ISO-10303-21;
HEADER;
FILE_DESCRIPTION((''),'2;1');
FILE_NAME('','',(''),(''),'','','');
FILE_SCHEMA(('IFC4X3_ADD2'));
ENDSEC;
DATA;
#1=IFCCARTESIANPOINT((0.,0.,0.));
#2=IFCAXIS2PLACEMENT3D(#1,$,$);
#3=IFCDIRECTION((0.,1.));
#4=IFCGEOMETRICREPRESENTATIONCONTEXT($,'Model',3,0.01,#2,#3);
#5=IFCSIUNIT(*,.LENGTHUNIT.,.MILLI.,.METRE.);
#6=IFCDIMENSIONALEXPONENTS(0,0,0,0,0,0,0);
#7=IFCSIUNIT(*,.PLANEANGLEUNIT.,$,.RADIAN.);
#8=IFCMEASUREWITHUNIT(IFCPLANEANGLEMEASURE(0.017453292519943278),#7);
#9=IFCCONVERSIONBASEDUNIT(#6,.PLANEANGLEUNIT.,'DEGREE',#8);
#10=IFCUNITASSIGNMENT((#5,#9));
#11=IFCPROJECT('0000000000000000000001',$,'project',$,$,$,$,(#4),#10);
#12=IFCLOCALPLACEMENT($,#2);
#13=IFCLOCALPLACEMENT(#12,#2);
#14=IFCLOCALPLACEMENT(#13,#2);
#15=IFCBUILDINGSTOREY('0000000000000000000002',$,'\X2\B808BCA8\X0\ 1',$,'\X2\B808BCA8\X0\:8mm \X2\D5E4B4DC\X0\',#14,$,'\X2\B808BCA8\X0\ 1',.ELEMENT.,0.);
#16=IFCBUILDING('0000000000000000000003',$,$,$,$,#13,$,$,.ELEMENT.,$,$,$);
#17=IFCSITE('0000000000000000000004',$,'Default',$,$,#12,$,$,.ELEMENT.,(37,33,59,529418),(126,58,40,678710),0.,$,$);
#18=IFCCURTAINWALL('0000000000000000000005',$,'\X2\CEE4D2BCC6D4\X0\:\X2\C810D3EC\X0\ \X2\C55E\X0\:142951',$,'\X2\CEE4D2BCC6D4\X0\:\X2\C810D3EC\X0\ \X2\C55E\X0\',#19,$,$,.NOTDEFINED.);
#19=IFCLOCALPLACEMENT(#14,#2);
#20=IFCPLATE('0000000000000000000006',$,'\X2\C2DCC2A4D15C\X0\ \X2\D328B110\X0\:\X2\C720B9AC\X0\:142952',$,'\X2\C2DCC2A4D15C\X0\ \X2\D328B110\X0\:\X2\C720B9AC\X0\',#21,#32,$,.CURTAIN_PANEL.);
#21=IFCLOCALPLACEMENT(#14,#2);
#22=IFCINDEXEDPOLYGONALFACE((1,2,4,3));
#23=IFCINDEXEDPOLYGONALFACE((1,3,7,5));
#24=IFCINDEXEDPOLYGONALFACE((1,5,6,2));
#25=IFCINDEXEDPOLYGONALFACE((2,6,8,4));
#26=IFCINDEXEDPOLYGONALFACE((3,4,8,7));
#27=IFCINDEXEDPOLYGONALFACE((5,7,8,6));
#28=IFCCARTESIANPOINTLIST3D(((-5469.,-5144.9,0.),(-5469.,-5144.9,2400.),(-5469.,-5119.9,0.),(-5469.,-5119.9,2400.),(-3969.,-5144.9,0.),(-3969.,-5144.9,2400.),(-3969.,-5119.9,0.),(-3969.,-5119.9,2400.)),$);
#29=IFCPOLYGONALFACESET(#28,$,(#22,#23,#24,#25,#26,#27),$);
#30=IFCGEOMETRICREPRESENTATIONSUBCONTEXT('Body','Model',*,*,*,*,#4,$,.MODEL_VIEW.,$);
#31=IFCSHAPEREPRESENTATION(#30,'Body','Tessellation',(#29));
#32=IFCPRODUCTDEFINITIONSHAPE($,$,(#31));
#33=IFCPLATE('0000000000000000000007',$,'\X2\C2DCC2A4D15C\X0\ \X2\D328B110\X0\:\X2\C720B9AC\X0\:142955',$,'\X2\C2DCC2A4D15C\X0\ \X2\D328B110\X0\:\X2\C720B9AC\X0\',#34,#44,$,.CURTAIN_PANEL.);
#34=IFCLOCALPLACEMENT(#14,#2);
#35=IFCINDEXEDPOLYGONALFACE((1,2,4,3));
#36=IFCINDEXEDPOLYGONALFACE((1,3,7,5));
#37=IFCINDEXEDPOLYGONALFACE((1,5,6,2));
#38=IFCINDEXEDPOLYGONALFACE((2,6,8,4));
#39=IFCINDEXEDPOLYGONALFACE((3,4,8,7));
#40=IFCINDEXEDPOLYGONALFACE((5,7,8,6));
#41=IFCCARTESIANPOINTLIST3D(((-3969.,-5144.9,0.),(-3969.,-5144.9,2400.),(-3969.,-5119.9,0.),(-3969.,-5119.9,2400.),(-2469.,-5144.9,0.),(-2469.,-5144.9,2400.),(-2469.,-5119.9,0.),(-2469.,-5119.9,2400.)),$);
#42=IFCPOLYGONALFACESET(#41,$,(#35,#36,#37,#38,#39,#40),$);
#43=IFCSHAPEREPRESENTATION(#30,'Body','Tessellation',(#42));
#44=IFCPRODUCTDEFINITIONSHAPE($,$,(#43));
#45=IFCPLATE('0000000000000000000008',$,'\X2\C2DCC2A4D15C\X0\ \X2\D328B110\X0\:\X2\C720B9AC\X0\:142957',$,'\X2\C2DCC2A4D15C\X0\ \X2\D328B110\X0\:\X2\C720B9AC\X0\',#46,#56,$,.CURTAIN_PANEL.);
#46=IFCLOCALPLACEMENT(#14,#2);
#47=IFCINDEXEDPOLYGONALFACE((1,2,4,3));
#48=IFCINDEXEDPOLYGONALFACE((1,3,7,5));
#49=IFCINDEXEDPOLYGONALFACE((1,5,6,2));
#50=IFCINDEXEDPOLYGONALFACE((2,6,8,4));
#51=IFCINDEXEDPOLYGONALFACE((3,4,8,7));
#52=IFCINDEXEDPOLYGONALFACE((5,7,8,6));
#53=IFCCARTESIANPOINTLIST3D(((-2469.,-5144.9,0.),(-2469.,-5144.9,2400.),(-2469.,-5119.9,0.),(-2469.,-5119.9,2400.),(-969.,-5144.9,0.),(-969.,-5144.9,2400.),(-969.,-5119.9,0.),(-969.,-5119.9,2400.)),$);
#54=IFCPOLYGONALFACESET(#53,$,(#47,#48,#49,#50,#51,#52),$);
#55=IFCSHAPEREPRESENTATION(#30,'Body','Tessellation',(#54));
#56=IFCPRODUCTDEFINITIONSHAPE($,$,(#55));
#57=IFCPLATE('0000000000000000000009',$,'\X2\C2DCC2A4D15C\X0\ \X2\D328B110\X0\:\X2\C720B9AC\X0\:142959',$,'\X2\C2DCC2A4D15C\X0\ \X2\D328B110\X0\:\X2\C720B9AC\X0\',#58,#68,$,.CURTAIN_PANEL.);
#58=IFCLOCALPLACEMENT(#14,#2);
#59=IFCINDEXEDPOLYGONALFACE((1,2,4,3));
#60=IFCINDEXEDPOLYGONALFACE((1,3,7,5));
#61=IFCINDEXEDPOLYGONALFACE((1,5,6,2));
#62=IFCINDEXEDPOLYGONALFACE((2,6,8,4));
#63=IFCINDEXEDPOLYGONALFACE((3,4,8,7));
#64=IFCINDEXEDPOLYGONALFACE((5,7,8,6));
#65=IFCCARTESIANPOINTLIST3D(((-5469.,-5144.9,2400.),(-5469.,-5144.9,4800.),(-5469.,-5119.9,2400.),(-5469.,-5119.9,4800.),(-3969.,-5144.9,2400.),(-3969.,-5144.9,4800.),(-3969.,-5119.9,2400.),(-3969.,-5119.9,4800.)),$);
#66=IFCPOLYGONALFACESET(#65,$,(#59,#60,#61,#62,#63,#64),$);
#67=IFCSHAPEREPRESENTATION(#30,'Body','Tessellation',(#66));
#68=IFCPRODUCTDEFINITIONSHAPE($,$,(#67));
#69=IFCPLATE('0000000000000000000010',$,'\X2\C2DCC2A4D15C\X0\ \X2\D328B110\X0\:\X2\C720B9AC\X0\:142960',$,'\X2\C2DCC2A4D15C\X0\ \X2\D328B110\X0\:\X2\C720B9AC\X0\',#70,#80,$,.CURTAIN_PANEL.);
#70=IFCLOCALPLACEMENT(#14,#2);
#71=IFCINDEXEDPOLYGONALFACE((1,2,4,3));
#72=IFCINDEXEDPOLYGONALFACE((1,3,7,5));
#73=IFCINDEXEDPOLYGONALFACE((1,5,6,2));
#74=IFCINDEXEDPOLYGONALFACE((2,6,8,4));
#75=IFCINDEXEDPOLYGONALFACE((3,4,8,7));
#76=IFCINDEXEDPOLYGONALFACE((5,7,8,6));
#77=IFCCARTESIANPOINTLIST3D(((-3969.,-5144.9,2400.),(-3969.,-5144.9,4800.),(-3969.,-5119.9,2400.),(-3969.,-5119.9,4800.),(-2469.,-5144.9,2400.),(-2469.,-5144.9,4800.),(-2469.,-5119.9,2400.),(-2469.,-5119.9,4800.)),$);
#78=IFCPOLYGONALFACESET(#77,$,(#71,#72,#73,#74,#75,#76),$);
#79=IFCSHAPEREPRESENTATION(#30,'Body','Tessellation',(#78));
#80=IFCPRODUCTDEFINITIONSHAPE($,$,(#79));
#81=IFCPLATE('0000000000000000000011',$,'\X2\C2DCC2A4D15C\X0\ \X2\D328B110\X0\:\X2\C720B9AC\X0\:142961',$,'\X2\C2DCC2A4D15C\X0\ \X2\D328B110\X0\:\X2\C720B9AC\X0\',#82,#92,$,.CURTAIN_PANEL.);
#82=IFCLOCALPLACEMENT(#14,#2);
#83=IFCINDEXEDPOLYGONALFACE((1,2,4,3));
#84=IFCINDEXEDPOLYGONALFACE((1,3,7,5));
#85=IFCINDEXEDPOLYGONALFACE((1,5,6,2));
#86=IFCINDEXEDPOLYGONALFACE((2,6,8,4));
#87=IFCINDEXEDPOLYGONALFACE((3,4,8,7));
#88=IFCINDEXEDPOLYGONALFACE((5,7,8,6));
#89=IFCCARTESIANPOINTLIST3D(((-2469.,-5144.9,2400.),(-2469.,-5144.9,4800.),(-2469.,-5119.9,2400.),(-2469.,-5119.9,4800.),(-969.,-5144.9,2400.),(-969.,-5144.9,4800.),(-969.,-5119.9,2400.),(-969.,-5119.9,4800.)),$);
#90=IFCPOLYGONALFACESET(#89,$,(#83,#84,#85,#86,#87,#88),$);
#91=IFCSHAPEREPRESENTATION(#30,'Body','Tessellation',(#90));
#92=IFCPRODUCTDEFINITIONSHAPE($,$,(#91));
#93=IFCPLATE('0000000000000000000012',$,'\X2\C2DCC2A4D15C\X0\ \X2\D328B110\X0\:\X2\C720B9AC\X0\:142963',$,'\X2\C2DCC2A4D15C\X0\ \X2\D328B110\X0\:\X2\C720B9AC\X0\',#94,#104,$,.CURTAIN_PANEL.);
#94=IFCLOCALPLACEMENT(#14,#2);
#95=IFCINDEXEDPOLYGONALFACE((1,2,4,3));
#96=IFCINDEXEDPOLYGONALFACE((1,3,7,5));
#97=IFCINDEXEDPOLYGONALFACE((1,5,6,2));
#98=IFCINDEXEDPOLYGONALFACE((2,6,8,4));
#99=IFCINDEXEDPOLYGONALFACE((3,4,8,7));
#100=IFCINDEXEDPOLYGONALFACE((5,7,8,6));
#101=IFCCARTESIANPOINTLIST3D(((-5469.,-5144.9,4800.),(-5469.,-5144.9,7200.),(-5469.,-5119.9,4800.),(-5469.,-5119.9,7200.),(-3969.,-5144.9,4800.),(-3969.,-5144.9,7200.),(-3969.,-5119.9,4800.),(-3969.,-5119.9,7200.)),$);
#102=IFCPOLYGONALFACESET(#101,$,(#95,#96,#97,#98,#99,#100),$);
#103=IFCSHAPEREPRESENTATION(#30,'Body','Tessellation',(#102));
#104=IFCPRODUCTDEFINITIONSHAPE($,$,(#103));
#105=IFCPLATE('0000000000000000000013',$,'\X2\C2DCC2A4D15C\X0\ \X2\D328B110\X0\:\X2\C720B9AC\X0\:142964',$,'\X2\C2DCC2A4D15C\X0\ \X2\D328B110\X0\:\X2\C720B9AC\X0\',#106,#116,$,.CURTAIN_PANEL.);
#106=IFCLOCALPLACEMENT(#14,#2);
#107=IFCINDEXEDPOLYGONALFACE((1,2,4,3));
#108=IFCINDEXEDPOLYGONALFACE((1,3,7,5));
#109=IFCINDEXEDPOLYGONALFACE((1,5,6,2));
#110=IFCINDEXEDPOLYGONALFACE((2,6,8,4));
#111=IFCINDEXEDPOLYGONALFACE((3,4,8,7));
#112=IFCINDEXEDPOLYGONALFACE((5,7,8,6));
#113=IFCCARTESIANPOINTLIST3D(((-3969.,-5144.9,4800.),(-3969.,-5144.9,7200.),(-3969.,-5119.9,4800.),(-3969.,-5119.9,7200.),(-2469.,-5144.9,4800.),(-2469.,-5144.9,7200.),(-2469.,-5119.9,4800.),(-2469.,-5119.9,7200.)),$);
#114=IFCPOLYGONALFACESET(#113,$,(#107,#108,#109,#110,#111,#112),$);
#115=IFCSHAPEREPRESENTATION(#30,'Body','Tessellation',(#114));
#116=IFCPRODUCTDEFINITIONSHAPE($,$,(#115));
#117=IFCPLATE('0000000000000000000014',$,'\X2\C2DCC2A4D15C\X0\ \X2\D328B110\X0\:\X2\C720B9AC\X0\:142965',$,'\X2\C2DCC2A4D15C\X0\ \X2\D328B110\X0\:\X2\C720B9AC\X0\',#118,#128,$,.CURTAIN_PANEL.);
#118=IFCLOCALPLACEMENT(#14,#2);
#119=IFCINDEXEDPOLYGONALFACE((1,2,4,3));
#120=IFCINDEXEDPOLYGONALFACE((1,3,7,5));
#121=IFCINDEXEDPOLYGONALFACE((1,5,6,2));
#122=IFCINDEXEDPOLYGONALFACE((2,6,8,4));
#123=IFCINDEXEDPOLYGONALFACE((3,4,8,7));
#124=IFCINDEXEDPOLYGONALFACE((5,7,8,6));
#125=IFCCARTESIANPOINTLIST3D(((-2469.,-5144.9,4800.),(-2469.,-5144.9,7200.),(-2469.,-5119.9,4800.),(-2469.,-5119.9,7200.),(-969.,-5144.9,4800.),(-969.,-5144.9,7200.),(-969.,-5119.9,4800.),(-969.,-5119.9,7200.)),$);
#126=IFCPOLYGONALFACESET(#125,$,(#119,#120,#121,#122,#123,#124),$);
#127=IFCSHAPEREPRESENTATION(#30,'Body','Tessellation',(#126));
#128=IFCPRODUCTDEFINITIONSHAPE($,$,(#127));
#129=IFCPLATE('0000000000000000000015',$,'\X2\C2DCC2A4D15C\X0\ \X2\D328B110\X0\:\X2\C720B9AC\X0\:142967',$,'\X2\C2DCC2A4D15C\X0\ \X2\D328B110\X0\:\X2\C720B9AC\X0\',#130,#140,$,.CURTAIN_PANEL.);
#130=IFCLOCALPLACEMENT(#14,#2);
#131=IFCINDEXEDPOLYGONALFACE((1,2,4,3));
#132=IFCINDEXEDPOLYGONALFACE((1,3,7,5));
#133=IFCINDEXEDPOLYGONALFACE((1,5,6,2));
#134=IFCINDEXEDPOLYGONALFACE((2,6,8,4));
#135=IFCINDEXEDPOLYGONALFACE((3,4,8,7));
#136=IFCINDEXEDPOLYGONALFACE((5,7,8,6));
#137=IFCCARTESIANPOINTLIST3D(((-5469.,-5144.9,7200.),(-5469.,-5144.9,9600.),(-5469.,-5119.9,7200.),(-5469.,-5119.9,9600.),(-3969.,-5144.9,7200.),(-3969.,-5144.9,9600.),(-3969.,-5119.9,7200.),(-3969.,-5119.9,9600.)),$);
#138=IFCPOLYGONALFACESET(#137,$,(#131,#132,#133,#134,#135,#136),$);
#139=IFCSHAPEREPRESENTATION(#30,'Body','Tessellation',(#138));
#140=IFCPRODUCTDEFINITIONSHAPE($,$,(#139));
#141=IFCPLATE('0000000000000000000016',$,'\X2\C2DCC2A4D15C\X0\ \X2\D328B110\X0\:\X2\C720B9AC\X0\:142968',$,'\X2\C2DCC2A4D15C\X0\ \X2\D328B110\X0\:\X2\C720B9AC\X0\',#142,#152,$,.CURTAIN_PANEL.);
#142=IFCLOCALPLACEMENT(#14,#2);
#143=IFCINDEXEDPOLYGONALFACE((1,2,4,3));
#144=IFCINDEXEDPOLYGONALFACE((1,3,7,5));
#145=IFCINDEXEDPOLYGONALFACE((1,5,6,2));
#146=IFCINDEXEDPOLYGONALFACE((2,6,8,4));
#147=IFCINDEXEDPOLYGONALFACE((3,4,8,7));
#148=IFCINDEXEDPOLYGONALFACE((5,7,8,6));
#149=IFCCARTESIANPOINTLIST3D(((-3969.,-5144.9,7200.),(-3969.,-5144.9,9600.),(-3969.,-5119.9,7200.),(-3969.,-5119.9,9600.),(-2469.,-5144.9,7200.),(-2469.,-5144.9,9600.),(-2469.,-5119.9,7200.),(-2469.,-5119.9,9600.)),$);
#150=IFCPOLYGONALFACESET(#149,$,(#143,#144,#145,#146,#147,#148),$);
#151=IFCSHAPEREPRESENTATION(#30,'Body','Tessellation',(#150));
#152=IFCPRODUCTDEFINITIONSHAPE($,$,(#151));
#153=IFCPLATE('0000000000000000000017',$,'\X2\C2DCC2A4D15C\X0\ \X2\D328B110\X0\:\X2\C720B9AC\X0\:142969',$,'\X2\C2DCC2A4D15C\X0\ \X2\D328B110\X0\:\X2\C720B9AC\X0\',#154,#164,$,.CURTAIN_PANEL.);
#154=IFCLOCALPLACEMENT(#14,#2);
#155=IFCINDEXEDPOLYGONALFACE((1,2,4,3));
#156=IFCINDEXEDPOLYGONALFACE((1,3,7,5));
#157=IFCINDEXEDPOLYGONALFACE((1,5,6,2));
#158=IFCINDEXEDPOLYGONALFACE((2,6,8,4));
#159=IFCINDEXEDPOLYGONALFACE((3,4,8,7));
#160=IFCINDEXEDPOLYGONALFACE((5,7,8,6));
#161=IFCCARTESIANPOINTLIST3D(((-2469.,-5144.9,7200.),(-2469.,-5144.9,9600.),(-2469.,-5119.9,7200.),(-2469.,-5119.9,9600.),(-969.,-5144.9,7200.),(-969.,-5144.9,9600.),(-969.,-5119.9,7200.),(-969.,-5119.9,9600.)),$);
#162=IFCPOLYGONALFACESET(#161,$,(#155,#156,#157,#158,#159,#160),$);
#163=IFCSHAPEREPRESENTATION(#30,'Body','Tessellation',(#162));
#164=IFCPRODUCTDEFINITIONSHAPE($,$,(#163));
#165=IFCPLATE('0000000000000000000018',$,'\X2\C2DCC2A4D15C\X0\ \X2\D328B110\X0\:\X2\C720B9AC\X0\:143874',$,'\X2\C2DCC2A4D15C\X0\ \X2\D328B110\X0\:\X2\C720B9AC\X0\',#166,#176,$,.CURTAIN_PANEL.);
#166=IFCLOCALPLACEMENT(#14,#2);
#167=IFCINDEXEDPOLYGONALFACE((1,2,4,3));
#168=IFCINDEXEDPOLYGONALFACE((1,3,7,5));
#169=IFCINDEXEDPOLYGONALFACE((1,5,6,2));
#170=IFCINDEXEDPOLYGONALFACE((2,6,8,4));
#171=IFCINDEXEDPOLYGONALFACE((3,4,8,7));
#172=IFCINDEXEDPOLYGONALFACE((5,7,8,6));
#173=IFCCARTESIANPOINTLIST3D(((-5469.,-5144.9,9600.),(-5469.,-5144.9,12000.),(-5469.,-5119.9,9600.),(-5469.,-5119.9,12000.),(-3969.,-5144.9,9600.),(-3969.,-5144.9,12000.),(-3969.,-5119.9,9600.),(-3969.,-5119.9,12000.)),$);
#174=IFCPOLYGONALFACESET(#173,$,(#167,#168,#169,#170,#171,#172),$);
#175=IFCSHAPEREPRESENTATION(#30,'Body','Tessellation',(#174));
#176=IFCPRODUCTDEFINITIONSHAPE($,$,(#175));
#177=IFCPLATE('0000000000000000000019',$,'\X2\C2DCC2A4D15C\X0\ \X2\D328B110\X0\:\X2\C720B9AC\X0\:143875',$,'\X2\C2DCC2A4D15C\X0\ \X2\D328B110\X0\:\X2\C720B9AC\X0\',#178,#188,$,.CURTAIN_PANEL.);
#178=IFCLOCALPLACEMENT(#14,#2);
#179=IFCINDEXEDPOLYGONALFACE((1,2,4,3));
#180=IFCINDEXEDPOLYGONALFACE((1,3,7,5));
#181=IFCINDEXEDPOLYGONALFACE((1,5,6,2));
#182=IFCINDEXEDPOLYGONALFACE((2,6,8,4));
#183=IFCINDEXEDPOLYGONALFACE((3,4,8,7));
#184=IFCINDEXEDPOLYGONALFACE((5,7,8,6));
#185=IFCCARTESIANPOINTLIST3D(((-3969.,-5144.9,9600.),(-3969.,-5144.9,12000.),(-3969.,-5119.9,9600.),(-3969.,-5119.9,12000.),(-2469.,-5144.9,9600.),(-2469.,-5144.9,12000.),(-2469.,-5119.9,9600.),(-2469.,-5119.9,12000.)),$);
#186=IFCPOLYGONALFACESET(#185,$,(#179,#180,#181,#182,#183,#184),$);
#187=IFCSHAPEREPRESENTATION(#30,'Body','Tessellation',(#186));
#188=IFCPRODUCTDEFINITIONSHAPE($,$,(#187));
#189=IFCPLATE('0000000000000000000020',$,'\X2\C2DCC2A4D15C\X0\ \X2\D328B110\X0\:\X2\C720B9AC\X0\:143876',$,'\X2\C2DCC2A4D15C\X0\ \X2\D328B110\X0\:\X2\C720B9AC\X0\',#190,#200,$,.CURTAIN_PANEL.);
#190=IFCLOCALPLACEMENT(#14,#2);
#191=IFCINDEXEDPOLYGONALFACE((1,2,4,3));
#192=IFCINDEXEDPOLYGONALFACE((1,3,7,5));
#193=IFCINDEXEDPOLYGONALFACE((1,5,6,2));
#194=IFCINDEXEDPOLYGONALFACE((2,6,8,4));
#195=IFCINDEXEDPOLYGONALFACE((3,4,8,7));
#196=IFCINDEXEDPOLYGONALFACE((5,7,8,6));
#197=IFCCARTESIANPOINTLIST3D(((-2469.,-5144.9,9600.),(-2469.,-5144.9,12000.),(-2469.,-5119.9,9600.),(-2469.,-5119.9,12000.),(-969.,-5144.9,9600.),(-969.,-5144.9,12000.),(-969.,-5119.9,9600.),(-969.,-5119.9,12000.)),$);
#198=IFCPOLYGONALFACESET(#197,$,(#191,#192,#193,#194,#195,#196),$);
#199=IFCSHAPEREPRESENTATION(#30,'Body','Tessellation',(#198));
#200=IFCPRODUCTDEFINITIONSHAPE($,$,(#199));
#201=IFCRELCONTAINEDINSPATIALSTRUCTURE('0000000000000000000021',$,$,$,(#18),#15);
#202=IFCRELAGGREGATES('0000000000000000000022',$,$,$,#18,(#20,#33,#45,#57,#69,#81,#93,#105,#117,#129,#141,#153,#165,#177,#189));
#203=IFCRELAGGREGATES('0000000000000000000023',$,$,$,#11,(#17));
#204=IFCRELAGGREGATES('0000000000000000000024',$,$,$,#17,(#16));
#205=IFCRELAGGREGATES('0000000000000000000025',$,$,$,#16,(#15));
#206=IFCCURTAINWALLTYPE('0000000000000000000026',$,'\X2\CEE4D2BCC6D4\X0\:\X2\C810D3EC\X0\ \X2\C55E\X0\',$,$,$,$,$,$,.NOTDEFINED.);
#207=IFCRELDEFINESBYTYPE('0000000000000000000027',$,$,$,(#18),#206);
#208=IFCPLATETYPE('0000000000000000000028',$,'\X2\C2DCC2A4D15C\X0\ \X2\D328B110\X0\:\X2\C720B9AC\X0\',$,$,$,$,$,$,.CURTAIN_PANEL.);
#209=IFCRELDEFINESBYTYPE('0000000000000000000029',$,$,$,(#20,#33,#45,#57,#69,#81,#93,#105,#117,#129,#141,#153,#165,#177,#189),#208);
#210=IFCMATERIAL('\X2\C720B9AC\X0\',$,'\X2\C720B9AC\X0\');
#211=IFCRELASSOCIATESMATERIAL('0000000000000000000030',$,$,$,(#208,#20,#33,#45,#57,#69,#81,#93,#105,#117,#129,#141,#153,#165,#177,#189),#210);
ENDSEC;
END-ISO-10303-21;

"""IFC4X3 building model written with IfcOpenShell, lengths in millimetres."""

from ifc_helpers import new_model, entity, si_unit, converted_unit, direction, frame, origin, origin_2d_with_axis, place, context, subcontext, project, spatial, rectangle, extrude, source, transform, mapped, material, type_object, type_shapes, element, aggregate, save


model = new_model("IFC4X3")

# Units and contexts
model_context = context("Model", 3, precision=0.01, world=origin(), true_north=direction((0.0, 1.0)))
body_context = subcontext(model_context, "Body", "Model", "MODEL_VIEW")
ifc_project = project(units=[si_unit("LENGTHUNIT", "METRE", prefix="MILLI"), converted_unit("PLANEANGLEUNIT", "DEGREE", entity("IfcPlaneAngleMeasure", 0.017453292519943278), si_unit("PLANEANGLEUNIT", "RADIAN"), dimensions=[0, 0, 0, 0, 0, 0, 0])], contexts=[model_context])

# Site, building, storey
site_placement = place(None, origin())
site = spatial("IfcSite", under=ifc_project, at=site_placement, Name="Default", CompositionType="ELEMENT", RefLatitude=(37, 33, 59, 529418), RefLongitude=(126, 58, 40, 678710), RefElevation=0.0)
building_placement = place(site_placement, origin())
building = spatial("IfcBuilding", under=site, at=building_placement, CompositionType="ELEMENT")
storey_placement = place(building_placement, origin())
storey = spatial("IfcBuildingStorey", under=building, at=storey_placement, Name="레벨 1", ObjectType="레벨:8mm 헤드", LongName="레벨 1", CompositionType="ELEMENT", Elevation=0.0)

# Curtain wall, plates
curtain_wall_type = type_object("IfcCurtainWallType", Name="커튼월:점포 앞", PredefinedType="NOTDEFINED")
curtain_wall_placement = place(storey_placement, origin())
curtain_wall = element("IfcCurtainWall", 1, at=curtain_wall_placement, inside=storey, type_object=curtain_wall_type, Name="커튼월:점포 앞:142951", ObjectType="커튼월:점포 앞", PredefinedType="NOTDEFINED")
ifc_material_1 = material(Name="유리", Category="유리")
plate_type_1 = type_object("IfcPlateType", Name="시스템 패널:유리", PredefinedType="CURTAIN_PANEL", material=ifc_material_1)
shared_shape_1 = source(origin(), body_context, "Body", "SweptSolid", [
    extrude(rectangle(XDim=25.0, YDim=1500.0, at=origin_2d_with_axis()), frame((750.0, 12.5, 0.0), z_axis=(0.0, 0.0, 1.0), x_axis=(0.0, 1.0, 0.0)), (0.0, 0.0, 1.0), 2400.0),
])
type_shapes(plate_type_1, [shared_shape_1])
plate_1_placement = place(curtain_wall_placement, frame((-5469.0, -5144.9, 0.0)))
plate_1 = element("IfcPlate", 2, at=plate_1_placement, type_object=plate_type_1, material=ifc_material_1, Name="시스템 패널:유리:142952", ObjectType="시스템 패널:유리", PredefinedType="CURTAIN_PANEL", context=body_context, shape_type="MappedRepresentation", body=[
    mapped(shared_shape_1, transform((0.0, 0.0, 0.0), scale=1.0)),
])
plate_2_placement = place(curtain_wall_placement, frame((-3969.0, -5144.9, 0.0)))
plate_2 = element("IfcPlate", 3, at=plate_2_placement, type_object=plate_type_1, material=ifc_material_1, Name="시스템 패널:유리:142955", ObjectType="시스템 패널:유리", PredefinedType="CURTAIN_PANEL", context=body_context, shape_type="MappedRepresentation", body=[
    mapped(shared_shape_1, transform((0.0, 0.0, 0.0), scale=1.0)),
])
plate_3_placement = place(curtain_wall_placement, frame((-2469.0, -5144.9, 0.0)))
plate_3 = element("IfcPlate", 4, at=plate_3_placement, type_object=plate_type_1, material=ifc_material_1, Name="시스템 패널:유리:142957", ObjectType="시스템 패널:유리", PredefinedType="CURTAIN_PANEL", context=body_context, shape_type="MappedRepresentation", body=[
    mapped(shared_shape_1, transform((0.0, 0.0, 0.0), scale=1.0)),
])
plate_4_placement = place(curtain_wall_placement, frame((-5469.0, -5144.9, 2400.0)))
plate_4 = element("IfcPlate", 5, at=plate_4_placement, type_object=plate_type_1, material=ifc_material_1, Name="시스템 패널:유리:142959", ObjectType="시스템 패널:유리", PredefinedType="CURTAIN_PANEL", context=body_context, shape_type="MappedRepresentation", body=[
    mapped(shared_shape_1, transform((0.0, 0.0, 0.0), scale=1.0)),
])
plate_5_placement = place(curtain_wall_placement, frame((-3969.0, -5144.9, 2400.0)))
plate_5 = element("IfcPlate", 6, at=plate_5_placement, type_object=plate_type_1, material=ifc_material_1, Name="시스템 패널:유리:142960", ObjectType="시스템 패널:유리", PredefinedType="CURTAIN_PANEL", context=body_context, shape_type="MappedRepresentation", body=[
    mapped(shared_shape_1, transform((0.0, 0.0, 0.0), scale=1.0)),
])
plate_6_placement = place(curtain_wall_placement, frame((-2469.0, -5144.9, 2400.0)))
plate_6 = element("IfcPlate", 7, at=plate_6_placement, type_object=plate_type_1, material=ifc_material_1, Name="시스템 패널:유리:142961", ObjectType="시스템 패널:유리", PredefinedType="CURTAIN_PANEL", context=body_context, shape_type="MappedRepresentation", body=[
    mapped(shared_shape_1, transform((0.0, 0.0, 0.0), scale=1.0)),
])
plate_7_placement = place(curtain_wall_placement, frame((-5469.0, -5144.9, 4800.0)))
plate_7 = element("IfcPlate", 8, at=plate_7_placement, type_object=plate_type_1, material=ifc_material_1, Name="시스템 패널:유리:142963", ObjectType="시스템 패널:유리", PredefinedType="CURTAIN_PANEL", context=body_context, shape_type="MappedRepresentation", body=[
    mapped(shared_shape_1, transform((0.0, 0.0, 0.0), scale=1.0)),
])
plate_8_placement = place(curtain_wall_placement, frame((-3969.0, -5144.9, 4800.0)))
plate_8 = element("IfcPlate", 9, at=plate_8_placement, type_object=plate_type_1, material=ifc_material_1, Name="시스템 패널:유리:142964", ObjectType="시스템 패널:유리", PredefinedType="CURTAIN_PANEL", context=body_context, shape_type="MappedRepresentation", body=[
    mapped(shared_shape_1, transform((0.0, 0.0, 0.0), scale=1.0)),
])
plate_9_placement = place(curtain_wall_placement, frame((-2469.0, -5144.9, 4800.0)))
plate_9 = element("IfcPlate", 10, at=plate_9_placement, type_object=plate_type_1, material=ifc_material_1, Name="시스템 패널:유리:142965", ObjectType="시스템 패널:유리", PredefinedType="CURTAIN_PANEL", context=body_context, shape_type="MappedRepresentation", body=[
    mapped(shared_shape_1, transform((0.0, 0.0, 0.0), scale=1.0)),
])
plate_10_placement = place(curtain_wall_placement, frame((-5469.0, -5144.9, 7200.0)))
plate_10 = element("IfcPlate", 11, at=plate_10_placement, type_object=plate_type_1, material=ifc_material_1, Name="시스템 패널:유리:142967", ObjectType="시스템 패널:유리", PredefinedType="CURTAIN_PANEL", context=body_context, shape_type="MappedRepresentation", body=[
    mapped(shared_shape_1, transform((0.0, 0.0, 0.0), scale=1.0)),
])
plate_11_placement = place(curtain_wall_placement, frame((-3969.0, -5144.9, 7200.0)))
plate_11 = element("IfcPlate", 12, at=plate_11_placement, type_object=plate_type_1, material=ifc_material_1, Name="시스템 패널:유리:142968", ObjectType="시스템 패널:유리", PredefinedType="CURTAIN_PANEL", context=body_context, shape_type="MappedRepresentation", body=[
    mapped(shared_shape_1, transform((0.0, 0.0, 0.0), scale=1.0)),
])
plate_12_placement = place(curtain_wall_placement, frame((-2469.0, -5144.9, 7200.0)))
plate_12 = element("IfcPlate", 13, at=plate_12_placement, type_object=plate_type_1, material=ifc_material_1, Name="시스템 패널:유리:142969", ObjectType="시스템 패널:유리", PredefinedType="CURTAIN_PANEL", context=body_context, shape_type="MappedRepresentation", body=[
    mapped(shared_shape_1, transform((0.0, 0.0, 0.0), scale=1.0)),
])
plate_13_placement = place(curtain_wall_placement, frame((-5469.0, -5144.9, 9600.0)))
plate_13 = element("IfcPlate", 14, at=plate_13_placement, type_object=plate_type_1, material=ifc_material_1, Name="시스템 패널:유리:143874", ObjectType="시스템 패널:유리", PredefinedType="CURTAIN_PANEL", context=body_context, shape_type="MappedRepresentation", body=[
    mapped(shared_shape_1, transform((0.0, 0.0, 0.0), scale=1.0)),
])
plate_14_placement = place(curtain_wall_placement, frame((-3969.0, -5144.9, 9600.0)))
plate_14 = element("IfcPlate", 15, at=plate_14_placement, type_object=plate_type_1, material=ifc_material_1, Name="시스템 패널:유리:143875", ObjectType="시스템 패널:유리", PredefinedType="CURTAIN_PANEL", context=body_context, shape_type="MappedRepresentation", body=[
    mapped(shared_shape_1, transform((0.0, 0.0, 0.0), scale=1.0)),
])
plate_15_placement = place(curtain_wall_placement, frame((-2469.0, -5144.9, 9600.0)))
plate_15 = element("IfcPlate", 16, at=plate_15_placement, type_object=plate_type_1, material=ifc_material_1, Name="시스템 패널:유리:143876", ObjectType="시스템 패널:유리", PredefinedType="CURTAIN_PANEL", context=body_context, shape_type="MappedRepresentation", body=[
    mapped(shared_shape_1, transform((0.0, 0.0, 0.0), scale=1.0)),
])
aggregate(curtain_wall, [plate_1, plate_2, plate_3, plate_4, plate_5, plate_6, plate_7, plate_8, plate_9, plate_10, plate_11, plate_12, plate_13, plate_14, plate_15])

save(model, "model.ifc")
